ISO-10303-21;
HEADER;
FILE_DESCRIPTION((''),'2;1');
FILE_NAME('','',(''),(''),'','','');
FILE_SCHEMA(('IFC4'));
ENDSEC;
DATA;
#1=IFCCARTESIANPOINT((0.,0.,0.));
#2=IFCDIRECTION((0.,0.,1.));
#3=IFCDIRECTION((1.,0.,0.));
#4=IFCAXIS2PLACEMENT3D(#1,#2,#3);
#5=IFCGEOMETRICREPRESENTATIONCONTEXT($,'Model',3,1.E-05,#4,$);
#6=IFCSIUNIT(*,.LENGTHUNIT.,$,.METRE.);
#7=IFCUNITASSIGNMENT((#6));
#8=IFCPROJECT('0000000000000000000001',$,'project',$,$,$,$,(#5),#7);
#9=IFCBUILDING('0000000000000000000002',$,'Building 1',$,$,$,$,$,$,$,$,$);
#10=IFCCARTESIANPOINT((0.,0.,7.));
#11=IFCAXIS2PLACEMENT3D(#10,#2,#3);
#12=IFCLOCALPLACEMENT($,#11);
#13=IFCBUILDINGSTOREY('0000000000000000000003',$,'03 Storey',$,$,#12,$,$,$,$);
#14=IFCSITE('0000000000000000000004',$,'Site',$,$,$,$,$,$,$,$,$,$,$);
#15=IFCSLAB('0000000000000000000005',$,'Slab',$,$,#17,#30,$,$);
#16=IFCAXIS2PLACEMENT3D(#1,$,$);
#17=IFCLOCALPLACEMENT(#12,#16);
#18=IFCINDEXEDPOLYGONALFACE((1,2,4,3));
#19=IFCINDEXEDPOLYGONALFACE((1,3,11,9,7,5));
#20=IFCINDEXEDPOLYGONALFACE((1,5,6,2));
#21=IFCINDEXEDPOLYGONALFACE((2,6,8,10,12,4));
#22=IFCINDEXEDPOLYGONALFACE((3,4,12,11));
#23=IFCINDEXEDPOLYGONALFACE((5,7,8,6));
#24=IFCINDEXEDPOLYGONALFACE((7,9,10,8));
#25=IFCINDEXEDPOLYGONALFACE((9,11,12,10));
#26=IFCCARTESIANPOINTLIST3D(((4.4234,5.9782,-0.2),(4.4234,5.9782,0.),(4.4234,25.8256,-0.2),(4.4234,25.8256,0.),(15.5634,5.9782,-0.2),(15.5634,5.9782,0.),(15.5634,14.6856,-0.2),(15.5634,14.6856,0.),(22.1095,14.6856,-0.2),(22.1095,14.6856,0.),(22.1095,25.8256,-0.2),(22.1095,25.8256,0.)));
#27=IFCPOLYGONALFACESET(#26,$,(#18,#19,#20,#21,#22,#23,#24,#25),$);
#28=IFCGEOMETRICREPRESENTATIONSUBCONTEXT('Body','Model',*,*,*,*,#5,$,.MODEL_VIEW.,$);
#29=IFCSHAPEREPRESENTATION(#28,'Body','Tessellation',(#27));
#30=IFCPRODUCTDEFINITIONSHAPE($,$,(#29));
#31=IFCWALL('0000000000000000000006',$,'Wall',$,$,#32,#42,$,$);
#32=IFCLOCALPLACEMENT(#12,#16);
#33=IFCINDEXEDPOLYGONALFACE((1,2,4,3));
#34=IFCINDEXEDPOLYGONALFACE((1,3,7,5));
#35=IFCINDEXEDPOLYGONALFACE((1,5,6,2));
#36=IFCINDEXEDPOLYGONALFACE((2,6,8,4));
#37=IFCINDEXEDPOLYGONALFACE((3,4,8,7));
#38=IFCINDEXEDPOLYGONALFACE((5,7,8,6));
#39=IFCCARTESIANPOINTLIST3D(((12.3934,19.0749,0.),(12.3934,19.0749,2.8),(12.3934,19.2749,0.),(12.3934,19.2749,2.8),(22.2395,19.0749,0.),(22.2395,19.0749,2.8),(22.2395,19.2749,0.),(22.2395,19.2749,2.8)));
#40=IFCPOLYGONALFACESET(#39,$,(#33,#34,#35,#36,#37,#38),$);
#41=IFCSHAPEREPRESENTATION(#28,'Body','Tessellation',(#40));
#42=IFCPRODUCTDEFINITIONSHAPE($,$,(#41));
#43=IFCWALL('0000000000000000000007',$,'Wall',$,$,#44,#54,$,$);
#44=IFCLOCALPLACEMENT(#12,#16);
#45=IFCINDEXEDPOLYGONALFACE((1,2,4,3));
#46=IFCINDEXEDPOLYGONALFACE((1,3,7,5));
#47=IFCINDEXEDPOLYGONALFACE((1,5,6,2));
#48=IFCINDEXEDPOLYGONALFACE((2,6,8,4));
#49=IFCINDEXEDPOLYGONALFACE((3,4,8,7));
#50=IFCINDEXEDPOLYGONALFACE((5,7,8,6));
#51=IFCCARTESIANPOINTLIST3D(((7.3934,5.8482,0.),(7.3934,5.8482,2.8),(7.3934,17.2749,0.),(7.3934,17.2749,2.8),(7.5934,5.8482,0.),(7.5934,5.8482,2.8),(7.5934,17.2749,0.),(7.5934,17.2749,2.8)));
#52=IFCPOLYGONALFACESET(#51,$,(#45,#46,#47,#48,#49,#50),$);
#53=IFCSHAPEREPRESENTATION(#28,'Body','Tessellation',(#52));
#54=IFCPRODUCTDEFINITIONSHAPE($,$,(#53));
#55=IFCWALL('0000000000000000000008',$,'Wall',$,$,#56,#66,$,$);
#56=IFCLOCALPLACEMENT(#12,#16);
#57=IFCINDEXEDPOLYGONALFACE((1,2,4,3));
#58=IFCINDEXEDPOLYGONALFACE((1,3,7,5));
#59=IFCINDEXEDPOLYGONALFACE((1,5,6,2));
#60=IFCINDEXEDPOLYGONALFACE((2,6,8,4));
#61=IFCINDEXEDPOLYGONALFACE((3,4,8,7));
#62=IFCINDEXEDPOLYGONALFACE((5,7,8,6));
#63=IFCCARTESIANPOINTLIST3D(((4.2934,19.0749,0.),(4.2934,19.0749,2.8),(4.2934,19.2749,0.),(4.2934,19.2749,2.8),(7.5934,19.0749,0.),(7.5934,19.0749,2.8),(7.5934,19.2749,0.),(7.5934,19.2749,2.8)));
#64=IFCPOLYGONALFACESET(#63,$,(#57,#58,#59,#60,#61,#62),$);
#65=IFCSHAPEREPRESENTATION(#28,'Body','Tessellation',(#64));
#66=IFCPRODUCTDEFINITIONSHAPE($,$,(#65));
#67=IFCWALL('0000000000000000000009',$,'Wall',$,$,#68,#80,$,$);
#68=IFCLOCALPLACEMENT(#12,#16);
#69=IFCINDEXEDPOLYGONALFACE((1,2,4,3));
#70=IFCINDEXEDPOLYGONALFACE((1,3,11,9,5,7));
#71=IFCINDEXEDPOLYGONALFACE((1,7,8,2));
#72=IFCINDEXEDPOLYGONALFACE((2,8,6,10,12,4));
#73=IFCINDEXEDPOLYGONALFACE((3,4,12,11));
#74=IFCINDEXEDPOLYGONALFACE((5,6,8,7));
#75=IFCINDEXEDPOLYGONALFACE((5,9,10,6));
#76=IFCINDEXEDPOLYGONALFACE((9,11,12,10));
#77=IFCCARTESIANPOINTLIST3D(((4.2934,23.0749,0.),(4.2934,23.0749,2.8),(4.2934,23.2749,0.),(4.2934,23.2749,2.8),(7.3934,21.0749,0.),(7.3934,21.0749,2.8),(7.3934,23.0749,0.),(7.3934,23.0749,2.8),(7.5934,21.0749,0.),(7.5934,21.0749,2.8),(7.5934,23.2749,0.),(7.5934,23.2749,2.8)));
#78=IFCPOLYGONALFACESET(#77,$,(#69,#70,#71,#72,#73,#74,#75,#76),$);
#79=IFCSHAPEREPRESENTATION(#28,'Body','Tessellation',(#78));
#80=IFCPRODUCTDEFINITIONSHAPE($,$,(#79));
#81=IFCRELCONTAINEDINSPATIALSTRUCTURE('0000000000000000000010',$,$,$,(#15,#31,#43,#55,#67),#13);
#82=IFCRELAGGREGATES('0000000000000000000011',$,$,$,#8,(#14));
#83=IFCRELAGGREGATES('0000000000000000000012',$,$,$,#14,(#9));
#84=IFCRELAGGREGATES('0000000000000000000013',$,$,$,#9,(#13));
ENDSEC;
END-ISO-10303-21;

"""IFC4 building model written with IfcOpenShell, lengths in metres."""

from ifc_helpers import new_model, si_unit, frame, origin_with_axes, place, context, subcontext, project, spatial, line, indexed_curve, outline, extrude, element, save


model = new_model("IFC4")

# Units and contexts
model_context = context("Model", 3, precision=1e-05, world=origin_with_axes())
body_context = subcontext(model_context, "Body", "Model", "MODEL_VIEW")
ifc_project = project(units=[si_unit("LENGTHUNIT", "METRE")], contexts=[model_context])

# Site, building, storey
site = spatial("IfcSite", under=ifc_project, Name="Site")
building = spatial("IfcBuilding", under=site, Name="Building 1")
storey_placement = place(None, frame((0.0, 0.0, 7.0), z_axis=(0.0, 0.0, 1.0), x_axis=(1.0, 0.0, 0.0)))
storey = spatial("IfcBuildingStorey", under=building, at=storey_placement, Name="03 Storey")

# Slab
slab_placement = place(storey_placement, origin_with_axes())
element("IfcSlab", 1, at=slab_placement, inside=storey, Name="Slab", context=body_context, shape_type="SweptSolid", body=[
    extrude(outline(indexed_curve([(15.5634, 14.6856), (22.1095, 14.6856), (22.1095, 25.8256), (4.4234, 25.8256), (4.4234, 5.9782), (15.5634, 5.9782)], segments=[line(1, 2), line(2, 3), line(3, 4), line(4, 5), line(5, 6)])), origin_with_axes(), (0.0, 0.0, -1.0), 0.2),
])

# Walls
wall_1_placement = place(storey_placement, origin_with_axes())
element("IfcWall", 2, at=wall_1_placement, inside=storey, Name="Wall", context=body_context, shape_type="SweptSolid", body=[
    extrude(outline(indexed_curve([(22.2395, 19.2749), (12.3934, 19.2749), (12.3934, 19.0749), (22.2395, 19.0749)], segments=[line(1, 2), line(2, 3), line(3, 4)])), origin_with_axes(), (0.0, 0.0, 1.0), 2.8),
])
wall_2_placement = place(storey_placement, origin_with_axes())
element("IfcWall", 3, at=wall_2_placement, inside=storey, Name="Wall", context=body_context, shape_type="SweptSolid", body=[
    extrude(outline(indexed_curve([(7.5934, 17.2749), (7.3934, 17.2749), (7.3934, 5.8482), (7.5934, 5.8482)], segments=[line(1, 2), line(2, 3), line(3, 4)])), origin_with_axes(), (0.0, 0.0, 1.0), 2.8),
])
wall_3_placement = place(storey_placement, origin_with_axes())
element("IfcWall", 4, at=wall_3_placement, inside=storey, Name="Wall", context=body_context, shape_type="SweptSolid", body=[
    extrude(outline(indexed_curve([(7.5934, 19.2749), (4.2934, 19.2749), (4.2934, 19.0749), (7.5934, 19.0749)], segments=[line(1, 2), line(2, 3), line(3, 4)])), origin_with_axes(), (0.0, 0.0, 1.0), 2.8),
])
wall_4_placement = place(storey_placement, origin_with_axes())
element("IfcWall", 5, at=wall_4_placement, inside=storey, Name="Wall", context=body_context, shape_type="SweptSolid", body=[
    extrude(outline(indexed_curve([(7.5934, 23.2749), (4.2934, 23.2749), (4.2934, 23.0749), (7.3934, 23.0749), (7.3934, 21.0749), (7.5934, 21.0749)], segments=[line(1, 2), line(2, 3), line(3, 4), line(4, 5), line(5, 6)])), origin_with_axes(), (0.0, 0.0, 1.0), 2.8),
])

save(model, "model.ifc")
